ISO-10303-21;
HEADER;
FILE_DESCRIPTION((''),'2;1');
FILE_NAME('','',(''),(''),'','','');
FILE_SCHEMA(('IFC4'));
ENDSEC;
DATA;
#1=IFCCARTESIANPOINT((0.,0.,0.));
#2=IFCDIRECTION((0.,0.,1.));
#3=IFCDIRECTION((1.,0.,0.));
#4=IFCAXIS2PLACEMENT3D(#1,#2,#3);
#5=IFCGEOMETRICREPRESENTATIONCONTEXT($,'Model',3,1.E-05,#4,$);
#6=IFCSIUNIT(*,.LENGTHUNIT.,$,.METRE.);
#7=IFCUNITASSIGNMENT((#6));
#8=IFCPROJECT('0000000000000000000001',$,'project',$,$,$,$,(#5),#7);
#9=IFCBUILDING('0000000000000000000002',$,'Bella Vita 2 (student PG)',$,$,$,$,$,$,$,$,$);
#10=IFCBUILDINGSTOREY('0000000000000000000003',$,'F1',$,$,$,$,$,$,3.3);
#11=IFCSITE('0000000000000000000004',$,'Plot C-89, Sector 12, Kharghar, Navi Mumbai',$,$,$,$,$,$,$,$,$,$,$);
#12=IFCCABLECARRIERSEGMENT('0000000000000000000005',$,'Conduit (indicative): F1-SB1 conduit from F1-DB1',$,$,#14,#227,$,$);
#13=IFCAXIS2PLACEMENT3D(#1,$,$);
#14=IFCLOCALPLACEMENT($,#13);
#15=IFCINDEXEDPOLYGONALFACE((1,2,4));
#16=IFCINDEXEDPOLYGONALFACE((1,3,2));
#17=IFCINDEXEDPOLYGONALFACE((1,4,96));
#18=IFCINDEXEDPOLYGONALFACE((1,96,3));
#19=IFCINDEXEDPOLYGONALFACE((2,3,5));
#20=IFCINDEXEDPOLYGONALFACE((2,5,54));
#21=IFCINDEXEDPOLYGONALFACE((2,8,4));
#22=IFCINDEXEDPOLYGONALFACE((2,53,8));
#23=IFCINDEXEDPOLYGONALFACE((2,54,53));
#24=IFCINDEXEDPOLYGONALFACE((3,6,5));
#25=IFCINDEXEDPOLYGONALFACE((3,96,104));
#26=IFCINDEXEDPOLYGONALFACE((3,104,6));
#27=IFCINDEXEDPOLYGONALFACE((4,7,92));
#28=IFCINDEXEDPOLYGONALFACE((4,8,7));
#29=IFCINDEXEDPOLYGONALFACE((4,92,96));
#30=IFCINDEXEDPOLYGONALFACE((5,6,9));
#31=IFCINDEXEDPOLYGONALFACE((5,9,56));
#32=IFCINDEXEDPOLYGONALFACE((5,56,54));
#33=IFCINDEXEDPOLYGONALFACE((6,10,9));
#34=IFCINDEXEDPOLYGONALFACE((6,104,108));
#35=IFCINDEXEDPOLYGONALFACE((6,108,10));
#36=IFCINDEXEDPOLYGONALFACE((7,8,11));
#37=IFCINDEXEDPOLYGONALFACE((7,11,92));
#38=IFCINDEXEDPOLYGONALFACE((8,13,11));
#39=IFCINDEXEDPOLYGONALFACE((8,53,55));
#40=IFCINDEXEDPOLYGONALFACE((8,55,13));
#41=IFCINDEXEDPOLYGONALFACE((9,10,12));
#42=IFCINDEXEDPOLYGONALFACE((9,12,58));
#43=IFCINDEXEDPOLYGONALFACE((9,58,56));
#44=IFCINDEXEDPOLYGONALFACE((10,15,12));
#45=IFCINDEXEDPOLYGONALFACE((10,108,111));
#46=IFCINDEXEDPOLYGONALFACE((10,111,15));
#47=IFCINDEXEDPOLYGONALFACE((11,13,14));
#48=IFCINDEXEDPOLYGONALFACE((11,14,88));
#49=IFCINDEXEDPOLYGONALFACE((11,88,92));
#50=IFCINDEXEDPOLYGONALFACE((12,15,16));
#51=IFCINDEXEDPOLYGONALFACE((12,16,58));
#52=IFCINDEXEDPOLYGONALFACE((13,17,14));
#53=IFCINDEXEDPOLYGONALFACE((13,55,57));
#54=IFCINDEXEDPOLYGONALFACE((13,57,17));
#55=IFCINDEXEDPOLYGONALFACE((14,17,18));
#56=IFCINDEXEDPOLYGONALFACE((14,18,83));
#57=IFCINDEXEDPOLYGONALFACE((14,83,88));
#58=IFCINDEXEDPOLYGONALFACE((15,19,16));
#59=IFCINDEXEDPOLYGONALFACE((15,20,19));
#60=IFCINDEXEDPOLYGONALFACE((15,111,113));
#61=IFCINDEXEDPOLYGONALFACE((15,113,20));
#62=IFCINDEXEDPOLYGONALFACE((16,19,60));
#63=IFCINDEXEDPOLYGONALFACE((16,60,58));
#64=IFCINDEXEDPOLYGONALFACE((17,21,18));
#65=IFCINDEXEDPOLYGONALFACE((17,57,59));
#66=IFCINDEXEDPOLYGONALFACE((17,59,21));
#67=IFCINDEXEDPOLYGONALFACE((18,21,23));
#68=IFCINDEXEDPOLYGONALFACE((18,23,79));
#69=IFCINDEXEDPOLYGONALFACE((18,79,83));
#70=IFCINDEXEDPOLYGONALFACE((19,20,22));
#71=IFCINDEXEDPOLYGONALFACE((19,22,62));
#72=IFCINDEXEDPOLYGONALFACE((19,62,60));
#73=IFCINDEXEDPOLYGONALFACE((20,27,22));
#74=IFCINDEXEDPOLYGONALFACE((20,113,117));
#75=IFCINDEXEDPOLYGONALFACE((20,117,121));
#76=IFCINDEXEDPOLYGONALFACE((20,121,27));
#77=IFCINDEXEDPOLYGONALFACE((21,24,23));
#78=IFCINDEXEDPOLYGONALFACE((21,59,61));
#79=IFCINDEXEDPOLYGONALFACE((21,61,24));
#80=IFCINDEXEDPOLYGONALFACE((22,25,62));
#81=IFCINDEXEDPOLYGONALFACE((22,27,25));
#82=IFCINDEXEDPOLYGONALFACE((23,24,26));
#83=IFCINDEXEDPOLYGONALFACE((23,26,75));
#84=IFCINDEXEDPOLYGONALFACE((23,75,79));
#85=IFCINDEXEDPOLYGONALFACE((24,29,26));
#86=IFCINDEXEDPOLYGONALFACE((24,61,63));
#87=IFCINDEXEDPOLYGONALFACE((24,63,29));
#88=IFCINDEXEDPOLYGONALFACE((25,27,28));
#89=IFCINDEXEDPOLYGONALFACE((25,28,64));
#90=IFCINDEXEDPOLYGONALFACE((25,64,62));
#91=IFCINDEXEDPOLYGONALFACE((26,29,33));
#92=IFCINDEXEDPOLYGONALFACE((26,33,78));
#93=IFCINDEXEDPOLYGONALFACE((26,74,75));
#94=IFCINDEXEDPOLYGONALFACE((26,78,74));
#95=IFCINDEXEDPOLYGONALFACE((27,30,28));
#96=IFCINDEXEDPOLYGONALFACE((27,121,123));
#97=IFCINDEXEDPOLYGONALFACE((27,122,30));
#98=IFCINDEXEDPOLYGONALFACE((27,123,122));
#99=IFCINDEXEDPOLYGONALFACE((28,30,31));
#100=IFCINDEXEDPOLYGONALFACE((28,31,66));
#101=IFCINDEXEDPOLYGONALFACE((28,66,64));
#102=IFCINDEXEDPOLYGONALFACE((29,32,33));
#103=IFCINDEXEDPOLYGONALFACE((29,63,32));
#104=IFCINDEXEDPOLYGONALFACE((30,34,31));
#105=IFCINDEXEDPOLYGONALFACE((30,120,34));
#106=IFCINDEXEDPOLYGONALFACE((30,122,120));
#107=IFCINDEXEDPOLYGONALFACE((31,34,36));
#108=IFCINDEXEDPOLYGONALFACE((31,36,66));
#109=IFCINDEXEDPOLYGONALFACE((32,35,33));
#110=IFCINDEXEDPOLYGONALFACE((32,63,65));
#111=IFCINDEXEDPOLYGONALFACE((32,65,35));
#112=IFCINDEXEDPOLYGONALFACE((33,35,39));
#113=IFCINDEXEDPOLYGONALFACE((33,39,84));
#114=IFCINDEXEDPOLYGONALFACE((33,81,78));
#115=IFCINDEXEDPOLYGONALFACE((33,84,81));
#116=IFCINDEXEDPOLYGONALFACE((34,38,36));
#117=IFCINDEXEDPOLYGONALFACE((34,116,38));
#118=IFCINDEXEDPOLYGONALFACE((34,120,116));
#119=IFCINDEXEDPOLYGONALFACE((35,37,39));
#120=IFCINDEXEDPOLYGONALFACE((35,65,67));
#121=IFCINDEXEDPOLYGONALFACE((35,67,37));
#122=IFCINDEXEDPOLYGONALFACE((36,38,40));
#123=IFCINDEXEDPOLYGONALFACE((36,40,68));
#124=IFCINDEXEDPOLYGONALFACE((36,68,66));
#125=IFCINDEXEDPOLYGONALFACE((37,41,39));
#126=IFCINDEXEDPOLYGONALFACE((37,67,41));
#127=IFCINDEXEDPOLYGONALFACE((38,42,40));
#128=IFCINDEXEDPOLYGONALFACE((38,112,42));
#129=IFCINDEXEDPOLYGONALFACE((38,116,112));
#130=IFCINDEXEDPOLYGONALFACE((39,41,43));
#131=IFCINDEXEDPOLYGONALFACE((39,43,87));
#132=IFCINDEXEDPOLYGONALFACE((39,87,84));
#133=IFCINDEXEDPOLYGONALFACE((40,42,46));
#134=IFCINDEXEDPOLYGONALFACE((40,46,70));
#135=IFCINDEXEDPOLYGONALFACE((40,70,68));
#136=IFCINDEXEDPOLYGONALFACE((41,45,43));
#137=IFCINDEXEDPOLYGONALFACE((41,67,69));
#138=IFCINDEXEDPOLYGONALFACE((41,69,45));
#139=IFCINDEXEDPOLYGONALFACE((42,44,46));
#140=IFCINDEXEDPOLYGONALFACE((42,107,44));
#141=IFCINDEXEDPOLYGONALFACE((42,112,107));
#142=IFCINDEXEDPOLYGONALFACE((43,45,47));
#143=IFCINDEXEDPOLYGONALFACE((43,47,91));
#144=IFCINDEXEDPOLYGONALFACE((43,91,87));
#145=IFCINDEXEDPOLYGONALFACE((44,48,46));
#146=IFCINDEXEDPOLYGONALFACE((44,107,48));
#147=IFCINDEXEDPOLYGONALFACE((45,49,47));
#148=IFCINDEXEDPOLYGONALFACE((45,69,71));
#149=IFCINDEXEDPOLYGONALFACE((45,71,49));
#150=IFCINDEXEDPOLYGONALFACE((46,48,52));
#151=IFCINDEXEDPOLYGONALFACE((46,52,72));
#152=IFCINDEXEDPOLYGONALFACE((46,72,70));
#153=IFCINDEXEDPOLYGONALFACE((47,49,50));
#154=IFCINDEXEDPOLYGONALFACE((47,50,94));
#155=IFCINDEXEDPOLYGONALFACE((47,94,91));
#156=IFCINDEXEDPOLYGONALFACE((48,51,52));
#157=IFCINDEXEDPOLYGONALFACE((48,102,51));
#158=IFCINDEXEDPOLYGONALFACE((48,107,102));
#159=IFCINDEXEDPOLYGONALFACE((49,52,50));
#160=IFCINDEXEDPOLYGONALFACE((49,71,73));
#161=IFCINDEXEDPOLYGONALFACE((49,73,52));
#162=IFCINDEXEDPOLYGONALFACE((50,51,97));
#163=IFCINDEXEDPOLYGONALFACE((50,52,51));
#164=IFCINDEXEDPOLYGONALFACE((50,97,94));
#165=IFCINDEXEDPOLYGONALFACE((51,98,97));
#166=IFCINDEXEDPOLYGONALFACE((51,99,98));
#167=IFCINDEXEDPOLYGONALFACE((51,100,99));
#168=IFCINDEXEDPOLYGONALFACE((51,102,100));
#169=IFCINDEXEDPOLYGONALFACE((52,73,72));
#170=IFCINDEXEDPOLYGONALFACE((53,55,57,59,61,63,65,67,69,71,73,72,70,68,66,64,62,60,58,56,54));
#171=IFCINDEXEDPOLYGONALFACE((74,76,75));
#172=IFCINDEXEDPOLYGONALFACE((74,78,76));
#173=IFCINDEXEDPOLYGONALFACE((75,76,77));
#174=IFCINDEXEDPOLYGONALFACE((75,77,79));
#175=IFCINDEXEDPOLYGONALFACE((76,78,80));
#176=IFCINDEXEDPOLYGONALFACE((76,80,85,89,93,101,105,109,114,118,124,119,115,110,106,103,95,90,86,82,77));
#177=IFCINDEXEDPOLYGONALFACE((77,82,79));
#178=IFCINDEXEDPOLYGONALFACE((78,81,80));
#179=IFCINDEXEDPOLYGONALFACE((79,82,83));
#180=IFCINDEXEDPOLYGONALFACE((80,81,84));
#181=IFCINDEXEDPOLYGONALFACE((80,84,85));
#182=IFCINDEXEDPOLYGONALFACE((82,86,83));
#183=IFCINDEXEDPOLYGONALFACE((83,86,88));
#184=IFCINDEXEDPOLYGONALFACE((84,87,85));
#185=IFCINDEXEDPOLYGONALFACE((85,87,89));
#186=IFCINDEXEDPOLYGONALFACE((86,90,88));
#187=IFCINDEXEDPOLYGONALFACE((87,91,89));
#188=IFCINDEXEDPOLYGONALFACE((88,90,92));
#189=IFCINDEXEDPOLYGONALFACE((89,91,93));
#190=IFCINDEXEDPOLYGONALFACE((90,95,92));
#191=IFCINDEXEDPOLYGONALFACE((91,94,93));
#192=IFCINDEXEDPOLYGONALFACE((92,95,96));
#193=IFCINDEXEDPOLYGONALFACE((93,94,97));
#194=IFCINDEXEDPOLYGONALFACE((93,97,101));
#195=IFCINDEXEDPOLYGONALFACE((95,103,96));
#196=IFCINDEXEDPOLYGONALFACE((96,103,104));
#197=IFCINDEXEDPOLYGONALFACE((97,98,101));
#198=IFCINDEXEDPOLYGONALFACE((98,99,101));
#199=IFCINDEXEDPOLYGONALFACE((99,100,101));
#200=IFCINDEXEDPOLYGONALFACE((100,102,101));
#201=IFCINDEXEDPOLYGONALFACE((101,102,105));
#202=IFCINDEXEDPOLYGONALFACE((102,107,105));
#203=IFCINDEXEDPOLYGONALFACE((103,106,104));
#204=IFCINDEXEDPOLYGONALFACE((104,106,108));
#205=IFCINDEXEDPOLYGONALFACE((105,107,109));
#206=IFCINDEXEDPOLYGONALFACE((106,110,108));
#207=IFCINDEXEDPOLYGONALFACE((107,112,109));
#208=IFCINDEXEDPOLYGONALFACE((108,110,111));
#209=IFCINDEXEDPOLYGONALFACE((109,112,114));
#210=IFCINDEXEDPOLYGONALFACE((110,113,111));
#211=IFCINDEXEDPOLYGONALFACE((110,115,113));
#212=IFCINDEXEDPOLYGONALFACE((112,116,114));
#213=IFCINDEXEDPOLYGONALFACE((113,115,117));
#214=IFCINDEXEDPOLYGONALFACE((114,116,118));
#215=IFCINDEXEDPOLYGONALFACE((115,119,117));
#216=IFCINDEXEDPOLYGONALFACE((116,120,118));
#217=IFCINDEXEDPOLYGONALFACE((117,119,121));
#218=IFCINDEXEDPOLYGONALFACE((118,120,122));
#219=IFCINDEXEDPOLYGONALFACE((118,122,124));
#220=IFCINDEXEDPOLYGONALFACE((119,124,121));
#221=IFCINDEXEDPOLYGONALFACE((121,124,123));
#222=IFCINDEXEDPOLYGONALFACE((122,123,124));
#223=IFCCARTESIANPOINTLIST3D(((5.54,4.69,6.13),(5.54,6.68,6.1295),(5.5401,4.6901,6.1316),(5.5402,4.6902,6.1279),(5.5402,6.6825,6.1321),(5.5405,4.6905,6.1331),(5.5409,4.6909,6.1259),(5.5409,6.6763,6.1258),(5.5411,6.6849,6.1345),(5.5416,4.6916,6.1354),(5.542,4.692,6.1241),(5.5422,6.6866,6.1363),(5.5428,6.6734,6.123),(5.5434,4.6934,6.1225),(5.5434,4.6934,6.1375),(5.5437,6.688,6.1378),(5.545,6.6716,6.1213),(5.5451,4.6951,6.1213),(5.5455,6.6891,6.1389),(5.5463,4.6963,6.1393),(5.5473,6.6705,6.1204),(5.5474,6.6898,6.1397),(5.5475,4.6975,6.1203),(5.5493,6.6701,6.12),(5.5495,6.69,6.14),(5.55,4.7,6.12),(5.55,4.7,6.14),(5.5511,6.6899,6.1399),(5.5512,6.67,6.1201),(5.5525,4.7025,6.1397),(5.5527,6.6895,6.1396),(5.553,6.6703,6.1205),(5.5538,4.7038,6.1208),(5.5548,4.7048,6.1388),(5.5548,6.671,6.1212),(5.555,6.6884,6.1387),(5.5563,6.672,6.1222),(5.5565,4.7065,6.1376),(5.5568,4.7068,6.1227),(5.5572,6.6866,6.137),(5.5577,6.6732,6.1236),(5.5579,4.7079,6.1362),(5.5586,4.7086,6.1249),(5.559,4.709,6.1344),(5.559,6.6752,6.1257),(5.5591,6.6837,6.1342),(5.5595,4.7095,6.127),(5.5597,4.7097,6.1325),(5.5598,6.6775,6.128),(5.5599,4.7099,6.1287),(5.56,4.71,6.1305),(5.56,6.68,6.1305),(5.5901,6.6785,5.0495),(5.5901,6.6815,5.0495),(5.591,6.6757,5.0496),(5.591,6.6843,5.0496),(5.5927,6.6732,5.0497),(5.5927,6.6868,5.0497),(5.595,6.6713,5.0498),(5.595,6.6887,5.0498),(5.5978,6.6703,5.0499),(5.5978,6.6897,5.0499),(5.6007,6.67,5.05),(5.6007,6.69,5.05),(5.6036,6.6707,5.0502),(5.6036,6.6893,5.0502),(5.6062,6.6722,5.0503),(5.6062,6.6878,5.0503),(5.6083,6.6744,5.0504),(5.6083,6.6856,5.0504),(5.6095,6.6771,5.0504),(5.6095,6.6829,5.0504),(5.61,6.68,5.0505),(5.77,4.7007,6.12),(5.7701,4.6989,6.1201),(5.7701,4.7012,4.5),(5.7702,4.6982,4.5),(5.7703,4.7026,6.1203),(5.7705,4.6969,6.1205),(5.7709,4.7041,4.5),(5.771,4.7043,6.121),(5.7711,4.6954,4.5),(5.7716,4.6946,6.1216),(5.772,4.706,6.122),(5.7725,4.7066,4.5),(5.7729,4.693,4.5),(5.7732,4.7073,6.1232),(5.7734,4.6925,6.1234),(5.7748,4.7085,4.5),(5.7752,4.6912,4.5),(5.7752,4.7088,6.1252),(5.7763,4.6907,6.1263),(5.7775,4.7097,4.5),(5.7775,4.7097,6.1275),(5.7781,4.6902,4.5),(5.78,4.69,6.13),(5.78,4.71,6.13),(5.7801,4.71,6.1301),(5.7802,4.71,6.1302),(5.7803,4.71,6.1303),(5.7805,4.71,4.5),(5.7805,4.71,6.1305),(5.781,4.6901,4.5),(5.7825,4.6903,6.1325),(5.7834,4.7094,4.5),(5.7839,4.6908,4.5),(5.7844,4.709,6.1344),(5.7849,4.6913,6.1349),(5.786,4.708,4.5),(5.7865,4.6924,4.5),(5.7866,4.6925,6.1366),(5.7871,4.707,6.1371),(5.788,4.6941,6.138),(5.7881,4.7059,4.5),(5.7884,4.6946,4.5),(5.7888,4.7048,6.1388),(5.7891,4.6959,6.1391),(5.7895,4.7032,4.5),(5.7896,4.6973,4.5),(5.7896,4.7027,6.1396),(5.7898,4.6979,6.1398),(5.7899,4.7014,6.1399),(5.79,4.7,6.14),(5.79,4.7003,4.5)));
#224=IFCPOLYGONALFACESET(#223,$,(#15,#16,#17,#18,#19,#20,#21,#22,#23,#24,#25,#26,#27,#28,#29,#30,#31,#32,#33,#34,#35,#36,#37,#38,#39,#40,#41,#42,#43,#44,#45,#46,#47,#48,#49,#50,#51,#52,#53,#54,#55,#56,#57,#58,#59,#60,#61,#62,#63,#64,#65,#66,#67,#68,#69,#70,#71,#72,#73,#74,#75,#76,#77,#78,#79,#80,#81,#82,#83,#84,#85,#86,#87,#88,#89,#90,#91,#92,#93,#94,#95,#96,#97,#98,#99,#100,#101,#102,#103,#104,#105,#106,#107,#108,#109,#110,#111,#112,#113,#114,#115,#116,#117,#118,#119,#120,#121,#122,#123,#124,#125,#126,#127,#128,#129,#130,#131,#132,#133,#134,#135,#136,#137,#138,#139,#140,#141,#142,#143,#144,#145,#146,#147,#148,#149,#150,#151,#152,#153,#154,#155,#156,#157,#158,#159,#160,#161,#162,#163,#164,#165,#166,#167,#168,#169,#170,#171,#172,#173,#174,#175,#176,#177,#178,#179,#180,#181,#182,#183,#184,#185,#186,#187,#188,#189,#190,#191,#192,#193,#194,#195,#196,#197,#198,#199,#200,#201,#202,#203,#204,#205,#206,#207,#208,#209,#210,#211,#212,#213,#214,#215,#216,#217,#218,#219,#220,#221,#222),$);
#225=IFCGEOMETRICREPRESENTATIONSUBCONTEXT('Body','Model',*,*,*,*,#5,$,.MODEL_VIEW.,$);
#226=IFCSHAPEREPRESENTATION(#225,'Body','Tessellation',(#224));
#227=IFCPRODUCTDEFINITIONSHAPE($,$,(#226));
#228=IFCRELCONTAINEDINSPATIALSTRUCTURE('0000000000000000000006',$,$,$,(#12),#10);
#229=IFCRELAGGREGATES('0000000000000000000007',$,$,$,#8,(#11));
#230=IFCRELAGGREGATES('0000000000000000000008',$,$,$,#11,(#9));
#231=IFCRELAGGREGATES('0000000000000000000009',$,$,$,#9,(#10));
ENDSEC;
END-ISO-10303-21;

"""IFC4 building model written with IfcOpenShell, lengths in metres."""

from ifc_helpers import new_model, entity, si_unit, origin, origin_with_axes, place, context, subcontext, project, spatial, element, save


model = new_model("IFC4")

# Units and contexts
model_context = context("Model", 3, precision=1e-05, world=origin_with_axes())
body_context = subcontext(model_context, "Body", "Model", "MODEL_VIEW")
ifc_project = project(units=[si_unit("LENGTHUNIT", "METRE")], contexts=[model_context])

# Site, building, storey
site = spatial("IfcSite", under=ifc_project, Name="Plot C-89, Sector 12, Kharghar, Navi Mumbai")
building = spatial("IfcBuilding", under=site, Name="Bella Vita 2 (student PG)")
storey = spatial("IfcBuildingStorey", under=building, Name="F1", Elevation=3.3)

# Cable carrier segment
cable_carrier_segment_placement = place(None, origin())
element("IfcCableCarrierSegment", 1, at=cable_carrier_segment_placement, inside=storey, Name="Conduit (indicative): F1-SB1 conduit from F1-DB1", context=body_context, shape_type="AdvancedSweptSolid", body=[
    entity("IfcSweptDiskSolid", entity("IfcPolyline", [entity("IfcCartesianPoint", [5.6, 6.68, 5.05]), entity("IfcCartesianPoint", [5.55, 6.68, 6.13]), entity("IfcCartesianPoint", [5.55, 4.7, 6.13]), entity("IfcCartesianPoint", [5.78, 4.7, 6.13]), entity("IfcCartesianPoint", [5.78, 4.7, 4.5])]), 0.01),
])

save(model, "model.ifc")
